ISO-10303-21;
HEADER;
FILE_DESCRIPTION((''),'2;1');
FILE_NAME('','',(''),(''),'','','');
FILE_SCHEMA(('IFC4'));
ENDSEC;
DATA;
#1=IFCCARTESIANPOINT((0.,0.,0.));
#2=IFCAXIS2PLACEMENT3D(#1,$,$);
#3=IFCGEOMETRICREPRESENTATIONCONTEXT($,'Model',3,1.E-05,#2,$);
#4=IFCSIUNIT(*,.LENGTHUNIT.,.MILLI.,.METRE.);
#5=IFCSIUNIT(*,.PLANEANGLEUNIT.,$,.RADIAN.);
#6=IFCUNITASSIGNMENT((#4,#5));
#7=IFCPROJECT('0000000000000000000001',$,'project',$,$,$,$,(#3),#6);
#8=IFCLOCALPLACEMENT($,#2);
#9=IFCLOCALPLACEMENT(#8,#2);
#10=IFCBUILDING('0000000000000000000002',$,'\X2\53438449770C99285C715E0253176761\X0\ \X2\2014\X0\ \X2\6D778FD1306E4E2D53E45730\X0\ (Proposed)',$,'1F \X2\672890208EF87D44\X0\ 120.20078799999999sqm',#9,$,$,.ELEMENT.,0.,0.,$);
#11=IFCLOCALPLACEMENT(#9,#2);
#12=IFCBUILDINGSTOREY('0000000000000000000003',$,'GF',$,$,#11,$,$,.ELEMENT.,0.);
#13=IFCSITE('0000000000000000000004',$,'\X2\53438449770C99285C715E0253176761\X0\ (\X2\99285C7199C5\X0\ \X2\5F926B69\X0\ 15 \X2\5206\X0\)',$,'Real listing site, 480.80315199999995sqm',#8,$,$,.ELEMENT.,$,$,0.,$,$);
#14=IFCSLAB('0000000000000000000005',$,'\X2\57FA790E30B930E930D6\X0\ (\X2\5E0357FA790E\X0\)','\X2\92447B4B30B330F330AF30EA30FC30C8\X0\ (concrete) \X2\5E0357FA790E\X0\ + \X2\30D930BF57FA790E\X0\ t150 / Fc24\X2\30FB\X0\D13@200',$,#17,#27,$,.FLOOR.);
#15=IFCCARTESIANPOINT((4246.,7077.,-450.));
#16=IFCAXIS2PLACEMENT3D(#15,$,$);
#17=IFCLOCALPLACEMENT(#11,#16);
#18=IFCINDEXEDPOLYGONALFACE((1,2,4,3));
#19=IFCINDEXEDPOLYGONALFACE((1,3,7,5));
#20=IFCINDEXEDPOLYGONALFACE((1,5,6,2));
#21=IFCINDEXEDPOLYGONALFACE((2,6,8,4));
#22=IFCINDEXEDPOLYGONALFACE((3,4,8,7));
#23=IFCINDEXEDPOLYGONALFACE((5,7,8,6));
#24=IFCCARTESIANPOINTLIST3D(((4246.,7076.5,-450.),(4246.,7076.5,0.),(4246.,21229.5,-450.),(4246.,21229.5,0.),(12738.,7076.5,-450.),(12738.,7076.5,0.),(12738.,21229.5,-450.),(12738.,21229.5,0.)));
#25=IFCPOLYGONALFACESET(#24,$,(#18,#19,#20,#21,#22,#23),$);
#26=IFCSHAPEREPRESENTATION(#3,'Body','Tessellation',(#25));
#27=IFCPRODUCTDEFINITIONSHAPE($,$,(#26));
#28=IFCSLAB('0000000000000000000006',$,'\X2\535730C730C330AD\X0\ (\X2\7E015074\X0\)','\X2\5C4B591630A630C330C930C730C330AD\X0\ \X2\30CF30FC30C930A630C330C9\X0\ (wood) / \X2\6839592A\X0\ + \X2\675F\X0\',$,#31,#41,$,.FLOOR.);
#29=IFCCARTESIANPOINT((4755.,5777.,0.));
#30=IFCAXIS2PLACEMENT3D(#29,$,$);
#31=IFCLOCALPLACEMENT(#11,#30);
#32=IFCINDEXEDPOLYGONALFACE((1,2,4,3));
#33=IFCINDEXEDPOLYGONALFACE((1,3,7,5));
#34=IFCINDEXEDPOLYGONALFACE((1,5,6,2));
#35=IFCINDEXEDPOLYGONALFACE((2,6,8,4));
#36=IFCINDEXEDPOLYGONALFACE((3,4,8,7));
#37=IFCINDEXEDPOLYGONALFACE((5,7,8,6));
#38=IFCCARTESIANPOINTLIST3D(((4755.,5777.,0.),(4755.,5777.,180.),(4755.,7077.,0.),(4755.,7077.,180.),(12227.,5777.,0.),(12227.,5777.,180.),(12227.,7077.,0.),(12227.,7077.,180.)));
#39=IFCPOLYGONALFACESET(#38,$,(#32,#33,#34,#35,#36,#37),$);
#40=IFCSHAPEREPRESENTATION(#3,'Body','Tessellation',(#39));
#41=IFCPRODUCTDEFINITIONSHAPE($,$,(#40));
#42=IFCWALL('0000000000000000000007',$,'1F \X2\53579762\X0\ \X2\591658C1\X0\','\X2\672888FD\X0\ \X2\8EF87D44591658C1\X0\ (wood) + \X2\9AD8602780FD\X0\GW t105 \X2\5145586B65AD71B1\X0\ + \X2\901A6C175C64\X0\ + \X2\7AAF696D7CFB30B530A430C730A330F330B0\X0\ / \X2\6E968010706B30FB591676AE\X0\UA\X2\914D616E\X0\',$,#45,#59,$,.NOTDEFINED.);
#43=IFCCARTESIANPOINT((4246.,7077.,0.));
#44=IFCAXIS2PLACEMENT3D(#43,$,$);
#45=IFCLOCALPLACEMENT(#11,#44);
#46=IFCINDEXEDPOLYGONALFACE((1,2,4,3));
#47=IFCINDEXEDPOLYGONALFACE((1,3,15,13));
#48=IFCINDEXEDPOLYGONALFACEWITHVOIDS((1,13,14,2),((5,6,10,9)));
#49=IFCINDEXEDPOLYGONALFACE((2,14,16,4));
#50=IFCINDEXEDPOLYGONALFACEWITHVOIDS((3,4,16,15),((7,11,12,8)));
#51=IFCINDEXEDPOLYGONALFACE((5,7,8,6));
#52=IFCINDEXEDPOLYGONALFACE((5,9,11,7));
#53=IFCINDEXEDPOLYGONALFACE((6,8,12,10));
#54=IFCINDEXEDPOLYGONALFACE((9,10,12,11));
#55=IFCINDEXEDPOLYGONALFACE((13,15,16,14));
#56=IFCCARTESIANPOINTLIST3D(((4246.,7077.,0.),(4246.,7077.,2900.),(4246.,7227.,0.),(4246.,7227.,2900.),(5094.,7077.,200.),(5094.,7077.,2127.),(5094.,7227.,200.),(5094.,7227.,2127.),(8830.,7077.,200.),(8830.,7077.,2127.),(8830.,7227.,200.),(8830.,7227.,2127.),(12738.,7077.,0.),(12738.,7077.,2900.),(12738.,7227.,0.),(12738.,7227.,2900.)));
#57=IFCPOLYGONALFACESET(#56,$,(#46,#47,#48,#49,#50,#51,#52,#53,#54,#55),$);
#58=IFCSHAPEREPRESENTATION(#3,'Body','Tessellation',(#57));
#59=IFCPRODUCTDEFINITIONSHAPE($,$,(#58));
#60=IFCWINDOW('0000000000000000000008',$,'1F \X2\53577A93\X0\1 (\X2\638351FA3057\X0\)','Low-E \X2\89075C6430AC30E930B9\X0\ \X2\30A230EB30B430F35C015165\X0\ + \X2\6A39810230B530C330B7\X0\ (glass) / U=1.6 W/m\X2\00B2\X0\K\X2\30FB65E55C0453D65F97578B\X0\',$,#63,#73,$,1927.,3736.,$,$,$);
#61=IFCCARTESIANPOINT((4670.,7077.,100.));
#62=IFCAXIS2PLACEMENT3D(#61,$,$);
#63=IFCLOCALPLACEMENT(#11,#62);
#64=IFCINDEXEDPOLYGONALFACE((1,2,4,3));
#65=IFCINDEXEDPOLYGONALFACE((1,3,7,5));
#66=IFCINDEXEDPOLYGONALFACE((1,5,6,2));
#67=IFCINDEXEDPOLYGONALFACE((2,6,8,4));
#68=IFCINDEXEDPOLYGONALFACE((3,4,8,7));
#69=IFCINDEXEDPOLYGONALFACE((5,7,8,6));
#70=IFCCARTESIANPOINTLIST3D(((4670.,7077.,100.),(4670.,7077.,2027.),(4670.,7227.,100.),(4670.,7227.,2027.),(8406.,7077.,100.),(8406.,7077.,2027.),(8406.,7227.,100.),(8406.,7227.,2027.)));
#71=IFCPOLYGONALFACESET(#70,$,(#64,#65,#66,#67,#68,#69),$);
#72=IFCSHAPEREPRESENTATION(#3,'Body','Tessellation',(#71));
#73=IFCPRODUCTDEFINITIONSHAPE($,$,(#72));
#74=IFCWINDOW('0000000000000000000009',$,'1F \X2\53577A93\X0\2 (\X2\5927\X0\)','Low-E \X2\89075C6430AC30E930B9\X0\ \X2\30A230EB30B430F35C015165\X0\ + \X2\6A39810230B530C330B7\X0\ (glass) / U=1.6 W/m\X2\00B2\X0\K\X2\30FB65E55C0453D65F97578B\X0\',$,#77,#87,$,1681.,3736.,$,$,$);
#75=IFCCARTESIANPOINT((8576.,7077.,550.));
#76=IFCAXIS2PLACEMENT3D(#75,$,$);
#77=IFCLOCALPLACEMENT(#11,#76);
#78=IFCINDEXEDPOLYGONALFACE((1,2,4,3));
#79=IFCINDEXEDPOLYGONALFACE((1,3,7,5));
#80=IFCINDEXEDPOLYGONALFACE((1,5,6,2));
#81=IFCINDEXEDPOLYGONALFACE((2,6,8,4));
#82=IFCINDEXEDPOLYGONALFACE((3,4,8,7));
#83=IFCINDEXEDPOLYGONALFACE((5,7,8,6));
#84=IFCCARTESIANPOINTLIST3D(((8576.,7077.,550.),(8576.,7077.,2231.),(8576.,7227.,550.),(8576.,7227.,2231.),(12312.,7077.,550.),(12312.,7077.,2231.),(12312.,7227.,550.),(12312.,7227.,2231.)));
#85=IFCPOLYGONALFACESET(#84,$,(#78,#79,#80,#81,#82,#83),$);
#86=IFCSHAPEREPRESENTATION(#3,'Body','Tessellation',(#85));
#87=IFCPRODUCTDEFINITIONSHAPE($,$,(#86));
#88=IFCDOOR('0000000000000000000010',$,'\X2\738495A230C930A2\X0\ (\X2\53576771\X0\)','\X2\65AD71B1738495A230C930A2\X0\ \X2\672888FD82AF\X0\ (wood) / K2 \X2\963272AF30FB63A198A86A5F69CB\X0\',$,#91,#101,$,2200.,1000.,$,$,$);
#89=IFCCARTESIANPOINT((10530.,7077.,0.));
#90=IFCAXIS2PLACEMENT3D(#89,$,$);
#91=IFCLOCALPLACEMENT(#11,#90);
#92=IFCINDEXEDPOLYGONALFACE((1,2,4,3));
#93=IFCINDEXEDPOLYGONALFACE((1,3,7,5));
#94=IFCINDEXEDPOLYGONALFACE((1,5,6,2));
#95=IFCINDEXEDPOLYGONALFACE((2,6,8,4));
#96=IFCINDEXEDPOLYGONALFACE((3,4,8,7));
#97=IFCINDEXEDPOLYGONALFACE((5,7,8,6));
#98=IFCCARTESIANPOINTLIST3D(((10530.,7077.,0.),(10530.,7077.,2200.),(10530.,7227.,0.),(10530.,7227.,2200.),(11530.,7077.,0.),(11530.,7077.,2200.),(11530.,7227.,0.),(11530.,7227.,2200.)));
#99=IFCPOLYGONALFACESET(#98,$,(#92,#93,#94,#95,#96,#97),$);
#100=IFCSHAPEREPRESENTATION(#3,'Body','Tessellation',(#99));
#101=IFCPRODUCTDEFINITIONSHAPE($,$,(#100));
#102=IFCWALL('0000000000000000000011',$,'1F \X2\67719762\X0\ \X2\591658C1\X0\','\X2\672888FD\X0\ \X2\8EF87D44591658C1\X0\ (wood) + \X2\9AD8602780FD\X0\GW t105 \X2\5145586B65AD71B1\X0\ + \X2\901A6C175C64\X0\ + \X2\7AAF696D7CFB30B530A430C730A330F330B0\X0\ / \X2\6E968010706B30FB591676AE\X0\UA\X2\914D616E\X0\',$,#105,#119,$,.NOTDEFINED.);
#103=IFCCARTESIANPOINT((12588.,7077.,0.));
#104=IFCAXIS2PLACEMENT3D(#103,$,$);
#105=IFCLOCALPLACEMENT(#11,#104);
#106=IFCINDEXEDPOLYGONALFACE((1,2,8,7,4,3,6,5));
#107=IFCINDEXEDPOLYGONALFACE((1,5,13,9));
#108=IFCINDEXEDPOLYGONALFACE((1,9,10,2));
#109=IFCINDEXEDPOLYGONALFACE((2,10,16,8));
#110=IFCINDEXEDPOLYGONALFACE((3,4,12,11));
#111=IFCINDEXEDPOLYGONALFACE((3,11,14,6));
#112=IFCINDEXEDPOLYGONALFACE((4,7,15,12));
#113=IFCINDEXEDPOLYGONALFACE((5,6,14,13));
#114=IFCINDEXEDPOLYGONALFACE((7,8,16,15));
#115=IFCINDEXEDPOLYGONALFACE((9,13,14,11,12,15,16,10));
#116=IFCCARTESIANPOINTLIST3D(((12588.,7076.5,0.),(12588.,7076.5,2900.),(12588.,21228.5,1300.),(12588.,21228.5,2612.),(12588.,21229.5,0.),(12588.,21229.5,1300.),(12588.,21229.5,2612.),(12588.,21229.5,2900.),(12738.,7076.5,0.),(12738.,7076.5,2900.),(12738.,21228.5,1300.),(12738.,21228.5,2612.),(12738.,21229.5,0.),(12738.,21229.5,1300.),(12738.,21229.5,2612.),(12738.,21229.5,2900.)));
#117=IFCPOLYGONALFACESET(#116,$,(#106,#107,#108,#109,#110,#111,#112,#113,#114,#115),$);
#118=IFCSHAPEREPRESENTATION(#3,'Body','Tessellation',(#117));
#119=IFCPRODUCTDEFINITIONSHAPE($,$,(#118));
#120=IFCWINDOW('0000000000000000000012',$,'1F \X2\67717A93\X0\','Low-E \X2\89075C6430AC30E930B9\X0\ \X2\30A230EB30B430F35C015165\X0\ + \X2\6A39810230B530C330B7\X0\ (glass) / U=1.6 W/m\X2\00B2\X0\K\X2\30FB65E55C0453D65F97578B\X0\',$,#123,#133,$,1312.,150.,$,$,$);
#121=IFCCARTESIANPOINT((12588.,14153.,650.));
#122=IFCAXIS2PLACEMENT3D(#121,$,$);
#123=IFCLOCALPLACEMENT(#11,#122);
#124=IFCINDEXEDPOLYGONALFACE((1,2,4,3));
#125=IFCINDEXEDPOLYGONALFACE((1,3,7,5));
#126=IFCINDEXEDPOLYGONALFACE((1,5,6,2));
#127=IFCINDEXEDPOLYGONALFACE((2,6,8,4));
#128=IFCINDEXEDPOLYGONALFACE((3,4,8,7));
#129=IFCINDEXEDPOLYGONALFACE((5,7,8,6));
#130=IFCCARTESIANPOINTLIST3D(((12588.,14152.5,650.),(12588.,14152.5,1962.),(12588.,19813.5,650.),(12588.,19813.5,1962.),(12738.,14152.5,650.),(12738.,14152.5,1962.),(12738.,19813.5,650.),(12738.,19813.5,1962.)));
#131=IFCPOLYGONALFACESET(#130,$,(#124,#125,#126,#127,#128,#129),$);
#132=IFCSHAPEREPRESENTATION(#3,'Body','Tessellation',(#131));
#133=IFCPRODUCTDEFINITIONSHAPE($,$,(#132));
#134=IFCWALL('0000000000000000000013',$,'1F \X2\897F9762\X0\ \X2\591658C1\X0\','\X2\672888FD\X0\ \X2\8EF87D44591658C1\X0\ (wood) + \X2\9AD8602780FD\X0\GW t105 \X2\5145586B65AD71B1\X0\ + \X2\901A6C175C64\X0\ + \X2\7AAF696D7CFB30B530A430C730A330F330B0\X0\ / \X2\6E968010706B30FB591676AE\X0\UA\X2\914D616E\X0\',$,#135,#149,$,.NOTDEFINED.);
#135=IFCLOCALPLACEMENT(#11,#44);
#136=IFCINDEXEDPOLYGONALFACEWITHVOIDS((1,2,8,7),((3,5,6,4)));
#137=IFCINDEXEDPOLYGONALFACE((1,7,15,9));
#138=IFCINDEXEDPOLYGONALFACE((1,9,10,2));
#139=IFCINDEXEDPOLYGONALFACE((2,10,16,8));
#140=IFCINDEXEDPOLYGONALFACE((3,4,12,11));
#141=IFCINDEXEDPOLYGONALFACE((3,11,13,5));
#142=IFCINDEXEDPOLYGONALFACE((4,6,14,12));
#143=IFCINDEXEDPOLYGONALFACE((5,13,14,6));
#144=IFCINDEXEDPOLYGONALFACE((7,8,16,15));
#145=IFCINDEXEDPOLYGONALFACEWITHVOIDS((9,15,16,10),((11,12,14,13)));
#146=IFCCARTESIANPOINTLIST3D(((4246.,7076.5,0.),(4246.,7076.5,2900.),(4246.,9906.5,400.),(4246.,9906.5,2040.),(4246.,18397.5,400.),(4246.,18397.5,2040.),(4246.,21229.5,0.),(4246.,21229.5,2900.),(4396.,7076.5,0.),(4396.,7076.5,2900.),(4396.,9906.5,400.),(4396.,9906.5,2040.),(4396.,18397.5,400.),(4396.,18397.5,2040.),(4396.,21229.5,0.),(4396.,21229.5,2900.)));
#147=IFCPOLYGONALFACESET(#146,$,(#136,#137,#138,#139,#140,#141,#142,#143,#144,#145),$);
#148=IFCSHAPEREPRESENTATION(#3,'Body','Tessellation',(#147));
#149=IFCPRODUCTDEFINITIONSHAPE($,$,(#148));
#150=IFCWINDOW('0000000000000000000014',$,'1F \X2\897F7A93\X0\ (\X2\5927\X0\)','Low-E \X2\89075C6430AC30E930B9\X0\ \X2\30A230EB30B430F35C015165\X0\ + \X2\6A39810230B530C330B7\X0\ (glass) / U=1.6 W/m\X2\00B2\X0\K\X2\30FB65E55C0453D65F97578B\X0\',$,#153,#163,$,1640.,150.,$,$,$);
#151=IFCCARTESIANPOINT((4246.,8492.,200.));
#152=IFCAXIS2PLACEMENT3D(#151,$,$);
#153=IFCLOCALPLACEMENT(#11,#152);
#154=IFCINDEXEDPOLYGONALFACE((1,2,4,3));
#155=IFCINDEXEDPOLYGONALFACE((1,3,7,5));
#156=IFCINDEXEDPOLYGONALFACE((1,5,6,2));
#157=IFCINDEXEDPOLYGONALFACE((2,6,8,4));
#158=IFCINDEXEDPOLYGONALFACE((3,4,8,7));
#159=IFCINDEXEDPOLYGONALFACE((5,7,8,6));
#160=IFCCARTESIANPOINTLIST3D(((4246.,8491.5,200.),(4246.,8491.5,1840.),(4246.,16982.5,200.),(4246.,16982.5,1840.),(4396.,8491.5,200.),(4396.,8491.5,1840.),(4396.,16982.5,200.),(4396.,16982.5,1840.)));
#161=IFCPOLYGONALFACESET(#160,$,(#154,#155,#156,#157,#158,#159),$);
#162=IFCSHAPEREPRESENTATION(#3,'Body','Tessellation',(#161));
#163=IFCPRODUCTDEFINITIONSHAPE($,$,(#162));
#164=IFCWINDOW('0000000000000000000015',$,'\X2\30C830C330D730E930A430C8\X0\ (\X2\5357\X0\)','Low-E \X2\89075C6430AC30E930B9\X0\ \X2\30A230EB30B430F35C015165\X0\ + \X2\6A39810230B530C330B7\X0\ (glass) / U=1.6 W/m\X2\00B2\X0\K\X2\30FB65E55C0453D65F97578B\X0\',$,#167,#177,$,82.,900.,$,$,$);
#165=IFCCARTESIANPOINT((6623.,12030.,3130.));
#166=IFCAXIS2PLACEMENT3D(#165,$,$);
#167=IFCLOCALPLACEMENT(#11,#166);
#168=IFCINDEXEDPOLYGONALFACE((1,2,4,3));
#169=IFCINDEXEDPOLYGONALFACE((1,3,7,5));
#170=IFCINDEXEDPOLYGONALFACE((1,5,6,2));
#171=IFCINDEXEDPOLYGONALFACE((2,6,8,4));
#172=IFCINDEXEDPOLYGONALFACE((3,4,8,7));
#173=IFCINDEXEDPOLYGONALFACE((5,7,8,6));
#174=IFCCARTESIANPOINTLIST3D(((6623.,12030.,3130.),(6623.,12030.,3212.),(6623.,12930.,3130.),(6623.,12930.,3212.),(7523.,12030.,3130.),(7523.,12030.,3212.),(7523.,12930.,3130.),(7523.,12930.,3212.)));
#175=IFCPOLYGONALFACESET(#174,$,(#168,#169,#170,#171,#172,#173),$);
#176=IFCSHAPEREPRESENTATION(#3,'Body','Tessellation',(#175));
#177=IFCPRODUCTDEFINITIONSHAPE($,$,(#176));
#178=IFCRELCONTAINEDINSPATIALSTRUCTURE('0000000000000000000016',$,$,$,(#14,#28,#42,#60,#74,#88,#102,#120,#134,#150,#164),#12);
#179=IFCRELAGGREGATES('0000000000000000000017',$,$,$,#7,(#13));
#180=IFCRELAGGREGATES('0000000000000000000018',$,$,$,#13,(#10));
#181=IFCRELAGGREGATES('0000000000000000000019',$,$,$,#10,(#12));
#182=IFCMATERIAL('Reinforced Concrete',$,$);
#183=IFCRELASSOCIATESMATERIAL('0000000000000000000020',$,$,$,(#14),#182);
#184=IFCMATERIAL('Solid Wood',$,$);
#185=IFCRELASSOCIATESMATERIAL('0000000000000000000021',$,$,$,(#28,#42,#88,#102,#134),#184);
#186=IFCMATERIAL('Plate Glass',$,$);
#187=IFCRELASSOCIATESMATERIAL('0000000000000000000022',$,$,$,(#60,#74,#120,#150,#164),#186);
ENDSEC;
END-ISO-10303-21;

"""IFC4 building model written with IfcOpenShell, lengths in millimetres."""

from ifc_helpers import new_model, si_unit, frame, frame_2d, origin, place, context, project, spatial, rectangle, extrude, material, element, fill, save


model = new_model("IFC4")

# Units and contexts
model_context = context("Model", 3, precision=1e-05, world=origin())
ifc_project = project(units=[si_unit("LENGTHUNIT", "METRE", prefix="MILLI"), si_unit("PLANEANGLEUNIT", "RADIAN")], contexts=[model_context])

# Site, building, storey
site_placement = place(None, origin())
site = spatial("IfcSite", under=ifc_project, at=site_placement, Name="千葉県館山市北条 (館山駅 徒歩 15 分)", ObjectType="Real listing site, 480.80315199999995sqm", CompositionType="ELEMENT", RefElevation=0.0)
building_placement = place(site_placement, origin())
building = spatial("IfcBuilding", under=site, at=building_placement, Name="千葉県館山市北条 — 海近の中古地 (Proposed)", ObjectType="1F 木造軸組 120.20078799999999sqm", CompositionType="ELEMENT", ElevationOfRefHeight=0.0, ElevationOfTerrain=0.0)
storey_placement = place(building_placement, origin())
storey = spatial("IfcBuildingStorey", under=building, at=storey_placement, Name="GF", CompositionType="ELEMENT", Elevation=0.0)

# Slabs
ifc_material_1 = material(Name="Reinforced Concrete")
slab_1_placement = place(storey_placement, frame((4246.0, 7077.0, -450.0)))
element("IfcSlab", 1, at=slab_1_placement, inside=storey, material=ifc_material_1, Name="基礎スラブ (布基礎)", Description="鉄筋コンクリート (concrete) 布基礎 + ベタ基礎 t150 / Fc24・D13@200", PredefinedType="FLOOR", context=model_context, shape_type="SweptSolid", body=[
    extrude(rectangle(XDim=8492.0, YDim=14153.0, at=frame_2d((4246.0, 7076.0))), frame((4246.0, 7077.0, -450.0)), (0.0, 0.0, 1.0), 450.0),
])
ifc_material_2 = material(Name="Solid Wood")
slab_2_placement = place(storey_placement, frame((4755.0, 5777.0, 0.0)))
element("IfcSlab", 2, at=slab_2_placement, inside=storey, material=ifc_material_2, Name="南デッキ (縁側)", Description="屋外ウッドデッキ ハードウッド (wood) / 根太 + 束", PredefinedType="FLOOR", context=model_context, shape_type="SweptSolid", body=[
    extrude(rectangle(XDim=7472.0, YDim=1300.0, at=frame_2d((3736.0, 650.0))), frame((4755.0, 5777.0, 0.0)), (0.0, 0.0, 1.0), 180.0),
])

# Wall, openings, windows, door
wall_1_placement = place(storey_placement, frame((4246.0, 7077.0, 0.0)))
wall_1 = element("IfcWall", 3, at=wall_1_placement, inside=storey, material=ifc_material_2, Name="1F 南面 外壁", Description="木製 軸組外壁 (wood) + 高性能GW t105 充填断熱 + 通気層 + 窯業系サイディング / 準耐火・外皮UA配慮", PredefinedType="NOTDEFINED", context=model_context, shape_type="SweptSolid", body=[
    extrude(rectangle(XDim=8492.0, YDim=150.0, at=frame_2d((4246.0, 75.0))), frame((4246.0, 7077.0, 0.0)), (0.0, 0.0, 1.0), 2900.0),
])
opening_1_placement = place(storey_placement, frame((4670.0, 7077.0, 100.0)))
opening_1 = element("IfcOpeningElement", 4, at=opening_1_placement, cuts=wall_1, PredefinedType="NOTDEFINED", context=model_context, shape_type="SweptSolid", body=[
    extrude(rectangle(XDim=3736.0, YDim=150.0, at=frame_2d((1868.0, 75.0))), frame((4670.0, 7077.0, 100.0)), (0.0, 0.0, 1.0), 1927.0),
])
opening_2_placement = place(storey_placement, frame((8576.0, 7077.0, 550.0)))
opening_2 = element("IfcOpeningElement", 5, at=opening_2_placement, cuts=wall_1, PredefinedType="NOTDEFINED", context=model_context, shape_type="SweptSolid", body=[
    extrude(rectangle(XDim=3736.0, YDim=150.0, at=frame_2d((1868.0, 75.0))), frame((8576.0, 7077.0, 550.0)), (0.0, 0.0, 1.0), 1681.0),
])
opening_3_placement = place(storey_placement, frame((10530.0, 7077.0, 0.0)))
opening_3 = element("IfcOpeningElement", 6, at=opening_3_placement, cuts=wall_1, PredefinedType="NOTDEFINED", context=model_context, shape_type="SweptSolid", body=[
    extrude(rectangle(XDim=1000.0, YDim=150.0, at=frame_2d((500.0, 75.0))), frame((10530.0, 7077.0, 0.0)), (0.0, 0.0, 1.0), 2200.0),
])
ifc_material_3 = material(Name="Plate Glass")
window_1_placement = place(storey_placement, frame((4670.0, 7077.0, 100.0)))
window_1 = element("IfcWindow", 7, at=window_1_placement, inside=storey, material=ifc_material_3, Name="1F 南窓1 (掃出し)", Description="Low-E 複層ガラス アルゴン封入 + 樹脂サッシ (glass) / U=1.6 W/m²K・日射取得型", OverallHeight=1927.0, OverallWidth=3736.0, context=model_context, shape_type="SweptSolid", body=[
    extrude(rectangle(XDim=3736.0, YDim=150.0, at=frame_2d((1868.0, 75.0))), frame((4670.0, 7077.0, 100.0)), (0.0, 0.0, 1.0), 1927.0),
])
fill(opening_1, window_1)
window_2_placement = place(storey_placement, frame((8576.0, 7077.0, 550.0)))
window_2 = element("IfcWindow", 8, at=window_2_placement, inside=storey, material=ifc_material_3, Name="1F 南窓2 (大)", Description="Low-E 複層ガラス アルゴン封入 + 樹脂サッシ (glass) / U=1.6 W/m²K・日射取得型", OverallHeight=1681.0, OverallWidth=3736.0, context=model_context, shape_type="SweptSolid", body=[
    extrude(rectangle(XDim=3736.0, YDim=150.0, at=frame_2d((1868.0, 75.0))), frame((8576.0, 7077.0, 550.0)), (0.0, 0.0, 1.0), 1681.0),
])
fill(opening_2, window_2)
door_placement = place(storey_placement, frame((10530.0, 7077.0, 0.0)))
door = element("IfcDoor", 9, at=door_placement, inside=storey, material=ifc_material_2, Name="玄関ドア (南東)", Description="断熱玄関ドア 木製芯 (wood) / K2 防犯・採風機構", OverallHeight=2200.0, OverallWidth=1000.0, context=model_context, shape_type="SweptSolid", body=[
    extrude(rectangle(XDim=1000.0, YDim=150.0, at=frame_2d((500.0, 75.0))), frame((10530.0, 7077.0, 0.0)), (0.0, 0.0, 1.0), 2200.0),
])
fill(opening_3, door)

# Walls, openings, windows
wall_2_placement = place(storey_placement, frame((12588.0, 7077.0, 0.0)))
wall_2 = element("IfcWall", 10, at=wall_2_placement, inside=storey, material=ifc_material_2, Name="1F 東面 外壁", Description="木製 軸組外壁 (wood) + 高性能GW t105 充填断熱 + 通気層 + 窯業系サイディング / 準耐火・外皮UA配慮", PredefinedType="NOTDEFINED", context=model_context, shape_type="SweptSolid", body=[
    extrude(rectangle(XDim=150.0, YDim=14153.0, at=frame_2d((75.0, 7076.0))), frame((12588.0, 7077.0, 0.0)), (0.0, 0.0, 1.0), 2900.0),
])
opening_4_placement = place(storey_placement, frame((12588.0, 14153.0, 650.0)))
opening_4 = element("IfcOpeningElement", 11, at=opening_4_placement, cuts=wall_2, PredefinedType="NOTDEFINED", context=model_context, shape_type="SweptSolid", body=[
    extrude(rectangle(XDim=150.0, YDim=5661.0, at=frame_2d((75.0, 2830.0))), frame((12588.0, 14153.0, 650.0)), (0.0, 0.0, 1.0), 1312.0),
])
window_3_placement = place(storey_placement, frame((12588.0, 14153.0, 650.0)))
window_3 = element("IfcWindow", 12, at=window_3_placement, inside=storey, material=ifc_material_3, Name="1F 東窓", Description="Low-E 複層ガラス アルゴン封入 + 樹脂サッシ (glass) / U=1.6 W/m²K・日射取得型", OverallHeight=1312.0, OverallWidth=150.0, context=model_context, shape_type="SweptSolid", body=[
    extrude(rectangle(XDim=150.0, YDim=5661.0, at=frame_2d((75.0, 2830.0))), frame((12588.0, 14153.0, 650.0)), (0.0, 0.0, 1.0), 1312.0),
])
fill(opening_4, window_3)
wall_3_placement = place(storey_placement, frame((4246.0, 7077.0, 0.0)))
wall_3 = element("IfcWall", 13, at=wall_3_placement, inside=storey, material=ifc_material_2, Name="1F 西面 外壁", Description="木製 軸組外壁 (wood) + 高性能GW t105 充填断熱 + 通気層 + 窯業系サイディング / 準耐火・外皮UA配慮", PredefinedType="NOTDEFINED", context=model_context, shape_type="SweptSolid", body=[
    extrude(rectangle(XDim=150.0, YDim=14153.0, at=frame_2d((75.0, 7076.0))), frame((4246.0, 7077.0, 0.0)), (0.0, 0.0, 1.0), 2900.0),
])
opening_5_placement = place(storey_placement, frame((4246.0, 8492.0, 200.0)))
opening_5 = element("IfcOpeningElement", 14, at=opening_5_placement, cuts=wall_3, PredefinedType="NOTDEFINED", context=model_context, shape_type="SweptSolid", body=[
    extrude(rectangle(XDim=150.0, YDim=8491.0, at=frame_2d((75.0, 4245.0))), frame((4246.0, 8492.0, 200.0)), (0.0, 0.0, 1.0), 1640.0),
])
window_4_placement = place(storey_placement, frame((4246.0, 8492.0, 200.0)))
window_4 = element("IfcWindow", 15, at=window_4_placement, inside=storey, material=ifc_material_3, Name="1F 西窓 (大)", Description="Low-E 複層ガラス アルゴン封入 + 樹脂サッシ (glass) / U=1.6 W/m²K・日射取得型", OverallHeight=1640.0, OverallWidth=150.0, context=model_context, shape_type="SweptSolid", body=[
    extrude(rectangle(XDim=150.0, YDim=8491.0, at=frame_2d((75.0, 4245.0))), frame((4246.0, 8492.0, 200.0)), (0.0, 0.0, 1.0), 1640.0),
])
fill(opening_5, window_4)

# Window
window_5_placement = place(storey_placement, frame((6623.0, 12030.0, 3130.0)))
element("IfcWindow", 16, at=window_5_placement, inside=storey, material=ifc_material_3, Name="トップライト (南)", Description="Low-E 複層ガラス アルゴン封入 + 樹脂サッシ (glass) / U=1.6 W/m²K・日射取得型", OverallHeight=82.0, OverallWidth=900.0, context=model_context, shape_type="SweptSolid", body=[
    extrude(rectangle(XDim=900.0, YDim=900.0, at=frame_2d((450.0, 450.0))), frame((6623.0, 12030.0, 3130.0)), (0.0, 0.0, 1.0), 82.0),
])

save(model, "model.ifc")
